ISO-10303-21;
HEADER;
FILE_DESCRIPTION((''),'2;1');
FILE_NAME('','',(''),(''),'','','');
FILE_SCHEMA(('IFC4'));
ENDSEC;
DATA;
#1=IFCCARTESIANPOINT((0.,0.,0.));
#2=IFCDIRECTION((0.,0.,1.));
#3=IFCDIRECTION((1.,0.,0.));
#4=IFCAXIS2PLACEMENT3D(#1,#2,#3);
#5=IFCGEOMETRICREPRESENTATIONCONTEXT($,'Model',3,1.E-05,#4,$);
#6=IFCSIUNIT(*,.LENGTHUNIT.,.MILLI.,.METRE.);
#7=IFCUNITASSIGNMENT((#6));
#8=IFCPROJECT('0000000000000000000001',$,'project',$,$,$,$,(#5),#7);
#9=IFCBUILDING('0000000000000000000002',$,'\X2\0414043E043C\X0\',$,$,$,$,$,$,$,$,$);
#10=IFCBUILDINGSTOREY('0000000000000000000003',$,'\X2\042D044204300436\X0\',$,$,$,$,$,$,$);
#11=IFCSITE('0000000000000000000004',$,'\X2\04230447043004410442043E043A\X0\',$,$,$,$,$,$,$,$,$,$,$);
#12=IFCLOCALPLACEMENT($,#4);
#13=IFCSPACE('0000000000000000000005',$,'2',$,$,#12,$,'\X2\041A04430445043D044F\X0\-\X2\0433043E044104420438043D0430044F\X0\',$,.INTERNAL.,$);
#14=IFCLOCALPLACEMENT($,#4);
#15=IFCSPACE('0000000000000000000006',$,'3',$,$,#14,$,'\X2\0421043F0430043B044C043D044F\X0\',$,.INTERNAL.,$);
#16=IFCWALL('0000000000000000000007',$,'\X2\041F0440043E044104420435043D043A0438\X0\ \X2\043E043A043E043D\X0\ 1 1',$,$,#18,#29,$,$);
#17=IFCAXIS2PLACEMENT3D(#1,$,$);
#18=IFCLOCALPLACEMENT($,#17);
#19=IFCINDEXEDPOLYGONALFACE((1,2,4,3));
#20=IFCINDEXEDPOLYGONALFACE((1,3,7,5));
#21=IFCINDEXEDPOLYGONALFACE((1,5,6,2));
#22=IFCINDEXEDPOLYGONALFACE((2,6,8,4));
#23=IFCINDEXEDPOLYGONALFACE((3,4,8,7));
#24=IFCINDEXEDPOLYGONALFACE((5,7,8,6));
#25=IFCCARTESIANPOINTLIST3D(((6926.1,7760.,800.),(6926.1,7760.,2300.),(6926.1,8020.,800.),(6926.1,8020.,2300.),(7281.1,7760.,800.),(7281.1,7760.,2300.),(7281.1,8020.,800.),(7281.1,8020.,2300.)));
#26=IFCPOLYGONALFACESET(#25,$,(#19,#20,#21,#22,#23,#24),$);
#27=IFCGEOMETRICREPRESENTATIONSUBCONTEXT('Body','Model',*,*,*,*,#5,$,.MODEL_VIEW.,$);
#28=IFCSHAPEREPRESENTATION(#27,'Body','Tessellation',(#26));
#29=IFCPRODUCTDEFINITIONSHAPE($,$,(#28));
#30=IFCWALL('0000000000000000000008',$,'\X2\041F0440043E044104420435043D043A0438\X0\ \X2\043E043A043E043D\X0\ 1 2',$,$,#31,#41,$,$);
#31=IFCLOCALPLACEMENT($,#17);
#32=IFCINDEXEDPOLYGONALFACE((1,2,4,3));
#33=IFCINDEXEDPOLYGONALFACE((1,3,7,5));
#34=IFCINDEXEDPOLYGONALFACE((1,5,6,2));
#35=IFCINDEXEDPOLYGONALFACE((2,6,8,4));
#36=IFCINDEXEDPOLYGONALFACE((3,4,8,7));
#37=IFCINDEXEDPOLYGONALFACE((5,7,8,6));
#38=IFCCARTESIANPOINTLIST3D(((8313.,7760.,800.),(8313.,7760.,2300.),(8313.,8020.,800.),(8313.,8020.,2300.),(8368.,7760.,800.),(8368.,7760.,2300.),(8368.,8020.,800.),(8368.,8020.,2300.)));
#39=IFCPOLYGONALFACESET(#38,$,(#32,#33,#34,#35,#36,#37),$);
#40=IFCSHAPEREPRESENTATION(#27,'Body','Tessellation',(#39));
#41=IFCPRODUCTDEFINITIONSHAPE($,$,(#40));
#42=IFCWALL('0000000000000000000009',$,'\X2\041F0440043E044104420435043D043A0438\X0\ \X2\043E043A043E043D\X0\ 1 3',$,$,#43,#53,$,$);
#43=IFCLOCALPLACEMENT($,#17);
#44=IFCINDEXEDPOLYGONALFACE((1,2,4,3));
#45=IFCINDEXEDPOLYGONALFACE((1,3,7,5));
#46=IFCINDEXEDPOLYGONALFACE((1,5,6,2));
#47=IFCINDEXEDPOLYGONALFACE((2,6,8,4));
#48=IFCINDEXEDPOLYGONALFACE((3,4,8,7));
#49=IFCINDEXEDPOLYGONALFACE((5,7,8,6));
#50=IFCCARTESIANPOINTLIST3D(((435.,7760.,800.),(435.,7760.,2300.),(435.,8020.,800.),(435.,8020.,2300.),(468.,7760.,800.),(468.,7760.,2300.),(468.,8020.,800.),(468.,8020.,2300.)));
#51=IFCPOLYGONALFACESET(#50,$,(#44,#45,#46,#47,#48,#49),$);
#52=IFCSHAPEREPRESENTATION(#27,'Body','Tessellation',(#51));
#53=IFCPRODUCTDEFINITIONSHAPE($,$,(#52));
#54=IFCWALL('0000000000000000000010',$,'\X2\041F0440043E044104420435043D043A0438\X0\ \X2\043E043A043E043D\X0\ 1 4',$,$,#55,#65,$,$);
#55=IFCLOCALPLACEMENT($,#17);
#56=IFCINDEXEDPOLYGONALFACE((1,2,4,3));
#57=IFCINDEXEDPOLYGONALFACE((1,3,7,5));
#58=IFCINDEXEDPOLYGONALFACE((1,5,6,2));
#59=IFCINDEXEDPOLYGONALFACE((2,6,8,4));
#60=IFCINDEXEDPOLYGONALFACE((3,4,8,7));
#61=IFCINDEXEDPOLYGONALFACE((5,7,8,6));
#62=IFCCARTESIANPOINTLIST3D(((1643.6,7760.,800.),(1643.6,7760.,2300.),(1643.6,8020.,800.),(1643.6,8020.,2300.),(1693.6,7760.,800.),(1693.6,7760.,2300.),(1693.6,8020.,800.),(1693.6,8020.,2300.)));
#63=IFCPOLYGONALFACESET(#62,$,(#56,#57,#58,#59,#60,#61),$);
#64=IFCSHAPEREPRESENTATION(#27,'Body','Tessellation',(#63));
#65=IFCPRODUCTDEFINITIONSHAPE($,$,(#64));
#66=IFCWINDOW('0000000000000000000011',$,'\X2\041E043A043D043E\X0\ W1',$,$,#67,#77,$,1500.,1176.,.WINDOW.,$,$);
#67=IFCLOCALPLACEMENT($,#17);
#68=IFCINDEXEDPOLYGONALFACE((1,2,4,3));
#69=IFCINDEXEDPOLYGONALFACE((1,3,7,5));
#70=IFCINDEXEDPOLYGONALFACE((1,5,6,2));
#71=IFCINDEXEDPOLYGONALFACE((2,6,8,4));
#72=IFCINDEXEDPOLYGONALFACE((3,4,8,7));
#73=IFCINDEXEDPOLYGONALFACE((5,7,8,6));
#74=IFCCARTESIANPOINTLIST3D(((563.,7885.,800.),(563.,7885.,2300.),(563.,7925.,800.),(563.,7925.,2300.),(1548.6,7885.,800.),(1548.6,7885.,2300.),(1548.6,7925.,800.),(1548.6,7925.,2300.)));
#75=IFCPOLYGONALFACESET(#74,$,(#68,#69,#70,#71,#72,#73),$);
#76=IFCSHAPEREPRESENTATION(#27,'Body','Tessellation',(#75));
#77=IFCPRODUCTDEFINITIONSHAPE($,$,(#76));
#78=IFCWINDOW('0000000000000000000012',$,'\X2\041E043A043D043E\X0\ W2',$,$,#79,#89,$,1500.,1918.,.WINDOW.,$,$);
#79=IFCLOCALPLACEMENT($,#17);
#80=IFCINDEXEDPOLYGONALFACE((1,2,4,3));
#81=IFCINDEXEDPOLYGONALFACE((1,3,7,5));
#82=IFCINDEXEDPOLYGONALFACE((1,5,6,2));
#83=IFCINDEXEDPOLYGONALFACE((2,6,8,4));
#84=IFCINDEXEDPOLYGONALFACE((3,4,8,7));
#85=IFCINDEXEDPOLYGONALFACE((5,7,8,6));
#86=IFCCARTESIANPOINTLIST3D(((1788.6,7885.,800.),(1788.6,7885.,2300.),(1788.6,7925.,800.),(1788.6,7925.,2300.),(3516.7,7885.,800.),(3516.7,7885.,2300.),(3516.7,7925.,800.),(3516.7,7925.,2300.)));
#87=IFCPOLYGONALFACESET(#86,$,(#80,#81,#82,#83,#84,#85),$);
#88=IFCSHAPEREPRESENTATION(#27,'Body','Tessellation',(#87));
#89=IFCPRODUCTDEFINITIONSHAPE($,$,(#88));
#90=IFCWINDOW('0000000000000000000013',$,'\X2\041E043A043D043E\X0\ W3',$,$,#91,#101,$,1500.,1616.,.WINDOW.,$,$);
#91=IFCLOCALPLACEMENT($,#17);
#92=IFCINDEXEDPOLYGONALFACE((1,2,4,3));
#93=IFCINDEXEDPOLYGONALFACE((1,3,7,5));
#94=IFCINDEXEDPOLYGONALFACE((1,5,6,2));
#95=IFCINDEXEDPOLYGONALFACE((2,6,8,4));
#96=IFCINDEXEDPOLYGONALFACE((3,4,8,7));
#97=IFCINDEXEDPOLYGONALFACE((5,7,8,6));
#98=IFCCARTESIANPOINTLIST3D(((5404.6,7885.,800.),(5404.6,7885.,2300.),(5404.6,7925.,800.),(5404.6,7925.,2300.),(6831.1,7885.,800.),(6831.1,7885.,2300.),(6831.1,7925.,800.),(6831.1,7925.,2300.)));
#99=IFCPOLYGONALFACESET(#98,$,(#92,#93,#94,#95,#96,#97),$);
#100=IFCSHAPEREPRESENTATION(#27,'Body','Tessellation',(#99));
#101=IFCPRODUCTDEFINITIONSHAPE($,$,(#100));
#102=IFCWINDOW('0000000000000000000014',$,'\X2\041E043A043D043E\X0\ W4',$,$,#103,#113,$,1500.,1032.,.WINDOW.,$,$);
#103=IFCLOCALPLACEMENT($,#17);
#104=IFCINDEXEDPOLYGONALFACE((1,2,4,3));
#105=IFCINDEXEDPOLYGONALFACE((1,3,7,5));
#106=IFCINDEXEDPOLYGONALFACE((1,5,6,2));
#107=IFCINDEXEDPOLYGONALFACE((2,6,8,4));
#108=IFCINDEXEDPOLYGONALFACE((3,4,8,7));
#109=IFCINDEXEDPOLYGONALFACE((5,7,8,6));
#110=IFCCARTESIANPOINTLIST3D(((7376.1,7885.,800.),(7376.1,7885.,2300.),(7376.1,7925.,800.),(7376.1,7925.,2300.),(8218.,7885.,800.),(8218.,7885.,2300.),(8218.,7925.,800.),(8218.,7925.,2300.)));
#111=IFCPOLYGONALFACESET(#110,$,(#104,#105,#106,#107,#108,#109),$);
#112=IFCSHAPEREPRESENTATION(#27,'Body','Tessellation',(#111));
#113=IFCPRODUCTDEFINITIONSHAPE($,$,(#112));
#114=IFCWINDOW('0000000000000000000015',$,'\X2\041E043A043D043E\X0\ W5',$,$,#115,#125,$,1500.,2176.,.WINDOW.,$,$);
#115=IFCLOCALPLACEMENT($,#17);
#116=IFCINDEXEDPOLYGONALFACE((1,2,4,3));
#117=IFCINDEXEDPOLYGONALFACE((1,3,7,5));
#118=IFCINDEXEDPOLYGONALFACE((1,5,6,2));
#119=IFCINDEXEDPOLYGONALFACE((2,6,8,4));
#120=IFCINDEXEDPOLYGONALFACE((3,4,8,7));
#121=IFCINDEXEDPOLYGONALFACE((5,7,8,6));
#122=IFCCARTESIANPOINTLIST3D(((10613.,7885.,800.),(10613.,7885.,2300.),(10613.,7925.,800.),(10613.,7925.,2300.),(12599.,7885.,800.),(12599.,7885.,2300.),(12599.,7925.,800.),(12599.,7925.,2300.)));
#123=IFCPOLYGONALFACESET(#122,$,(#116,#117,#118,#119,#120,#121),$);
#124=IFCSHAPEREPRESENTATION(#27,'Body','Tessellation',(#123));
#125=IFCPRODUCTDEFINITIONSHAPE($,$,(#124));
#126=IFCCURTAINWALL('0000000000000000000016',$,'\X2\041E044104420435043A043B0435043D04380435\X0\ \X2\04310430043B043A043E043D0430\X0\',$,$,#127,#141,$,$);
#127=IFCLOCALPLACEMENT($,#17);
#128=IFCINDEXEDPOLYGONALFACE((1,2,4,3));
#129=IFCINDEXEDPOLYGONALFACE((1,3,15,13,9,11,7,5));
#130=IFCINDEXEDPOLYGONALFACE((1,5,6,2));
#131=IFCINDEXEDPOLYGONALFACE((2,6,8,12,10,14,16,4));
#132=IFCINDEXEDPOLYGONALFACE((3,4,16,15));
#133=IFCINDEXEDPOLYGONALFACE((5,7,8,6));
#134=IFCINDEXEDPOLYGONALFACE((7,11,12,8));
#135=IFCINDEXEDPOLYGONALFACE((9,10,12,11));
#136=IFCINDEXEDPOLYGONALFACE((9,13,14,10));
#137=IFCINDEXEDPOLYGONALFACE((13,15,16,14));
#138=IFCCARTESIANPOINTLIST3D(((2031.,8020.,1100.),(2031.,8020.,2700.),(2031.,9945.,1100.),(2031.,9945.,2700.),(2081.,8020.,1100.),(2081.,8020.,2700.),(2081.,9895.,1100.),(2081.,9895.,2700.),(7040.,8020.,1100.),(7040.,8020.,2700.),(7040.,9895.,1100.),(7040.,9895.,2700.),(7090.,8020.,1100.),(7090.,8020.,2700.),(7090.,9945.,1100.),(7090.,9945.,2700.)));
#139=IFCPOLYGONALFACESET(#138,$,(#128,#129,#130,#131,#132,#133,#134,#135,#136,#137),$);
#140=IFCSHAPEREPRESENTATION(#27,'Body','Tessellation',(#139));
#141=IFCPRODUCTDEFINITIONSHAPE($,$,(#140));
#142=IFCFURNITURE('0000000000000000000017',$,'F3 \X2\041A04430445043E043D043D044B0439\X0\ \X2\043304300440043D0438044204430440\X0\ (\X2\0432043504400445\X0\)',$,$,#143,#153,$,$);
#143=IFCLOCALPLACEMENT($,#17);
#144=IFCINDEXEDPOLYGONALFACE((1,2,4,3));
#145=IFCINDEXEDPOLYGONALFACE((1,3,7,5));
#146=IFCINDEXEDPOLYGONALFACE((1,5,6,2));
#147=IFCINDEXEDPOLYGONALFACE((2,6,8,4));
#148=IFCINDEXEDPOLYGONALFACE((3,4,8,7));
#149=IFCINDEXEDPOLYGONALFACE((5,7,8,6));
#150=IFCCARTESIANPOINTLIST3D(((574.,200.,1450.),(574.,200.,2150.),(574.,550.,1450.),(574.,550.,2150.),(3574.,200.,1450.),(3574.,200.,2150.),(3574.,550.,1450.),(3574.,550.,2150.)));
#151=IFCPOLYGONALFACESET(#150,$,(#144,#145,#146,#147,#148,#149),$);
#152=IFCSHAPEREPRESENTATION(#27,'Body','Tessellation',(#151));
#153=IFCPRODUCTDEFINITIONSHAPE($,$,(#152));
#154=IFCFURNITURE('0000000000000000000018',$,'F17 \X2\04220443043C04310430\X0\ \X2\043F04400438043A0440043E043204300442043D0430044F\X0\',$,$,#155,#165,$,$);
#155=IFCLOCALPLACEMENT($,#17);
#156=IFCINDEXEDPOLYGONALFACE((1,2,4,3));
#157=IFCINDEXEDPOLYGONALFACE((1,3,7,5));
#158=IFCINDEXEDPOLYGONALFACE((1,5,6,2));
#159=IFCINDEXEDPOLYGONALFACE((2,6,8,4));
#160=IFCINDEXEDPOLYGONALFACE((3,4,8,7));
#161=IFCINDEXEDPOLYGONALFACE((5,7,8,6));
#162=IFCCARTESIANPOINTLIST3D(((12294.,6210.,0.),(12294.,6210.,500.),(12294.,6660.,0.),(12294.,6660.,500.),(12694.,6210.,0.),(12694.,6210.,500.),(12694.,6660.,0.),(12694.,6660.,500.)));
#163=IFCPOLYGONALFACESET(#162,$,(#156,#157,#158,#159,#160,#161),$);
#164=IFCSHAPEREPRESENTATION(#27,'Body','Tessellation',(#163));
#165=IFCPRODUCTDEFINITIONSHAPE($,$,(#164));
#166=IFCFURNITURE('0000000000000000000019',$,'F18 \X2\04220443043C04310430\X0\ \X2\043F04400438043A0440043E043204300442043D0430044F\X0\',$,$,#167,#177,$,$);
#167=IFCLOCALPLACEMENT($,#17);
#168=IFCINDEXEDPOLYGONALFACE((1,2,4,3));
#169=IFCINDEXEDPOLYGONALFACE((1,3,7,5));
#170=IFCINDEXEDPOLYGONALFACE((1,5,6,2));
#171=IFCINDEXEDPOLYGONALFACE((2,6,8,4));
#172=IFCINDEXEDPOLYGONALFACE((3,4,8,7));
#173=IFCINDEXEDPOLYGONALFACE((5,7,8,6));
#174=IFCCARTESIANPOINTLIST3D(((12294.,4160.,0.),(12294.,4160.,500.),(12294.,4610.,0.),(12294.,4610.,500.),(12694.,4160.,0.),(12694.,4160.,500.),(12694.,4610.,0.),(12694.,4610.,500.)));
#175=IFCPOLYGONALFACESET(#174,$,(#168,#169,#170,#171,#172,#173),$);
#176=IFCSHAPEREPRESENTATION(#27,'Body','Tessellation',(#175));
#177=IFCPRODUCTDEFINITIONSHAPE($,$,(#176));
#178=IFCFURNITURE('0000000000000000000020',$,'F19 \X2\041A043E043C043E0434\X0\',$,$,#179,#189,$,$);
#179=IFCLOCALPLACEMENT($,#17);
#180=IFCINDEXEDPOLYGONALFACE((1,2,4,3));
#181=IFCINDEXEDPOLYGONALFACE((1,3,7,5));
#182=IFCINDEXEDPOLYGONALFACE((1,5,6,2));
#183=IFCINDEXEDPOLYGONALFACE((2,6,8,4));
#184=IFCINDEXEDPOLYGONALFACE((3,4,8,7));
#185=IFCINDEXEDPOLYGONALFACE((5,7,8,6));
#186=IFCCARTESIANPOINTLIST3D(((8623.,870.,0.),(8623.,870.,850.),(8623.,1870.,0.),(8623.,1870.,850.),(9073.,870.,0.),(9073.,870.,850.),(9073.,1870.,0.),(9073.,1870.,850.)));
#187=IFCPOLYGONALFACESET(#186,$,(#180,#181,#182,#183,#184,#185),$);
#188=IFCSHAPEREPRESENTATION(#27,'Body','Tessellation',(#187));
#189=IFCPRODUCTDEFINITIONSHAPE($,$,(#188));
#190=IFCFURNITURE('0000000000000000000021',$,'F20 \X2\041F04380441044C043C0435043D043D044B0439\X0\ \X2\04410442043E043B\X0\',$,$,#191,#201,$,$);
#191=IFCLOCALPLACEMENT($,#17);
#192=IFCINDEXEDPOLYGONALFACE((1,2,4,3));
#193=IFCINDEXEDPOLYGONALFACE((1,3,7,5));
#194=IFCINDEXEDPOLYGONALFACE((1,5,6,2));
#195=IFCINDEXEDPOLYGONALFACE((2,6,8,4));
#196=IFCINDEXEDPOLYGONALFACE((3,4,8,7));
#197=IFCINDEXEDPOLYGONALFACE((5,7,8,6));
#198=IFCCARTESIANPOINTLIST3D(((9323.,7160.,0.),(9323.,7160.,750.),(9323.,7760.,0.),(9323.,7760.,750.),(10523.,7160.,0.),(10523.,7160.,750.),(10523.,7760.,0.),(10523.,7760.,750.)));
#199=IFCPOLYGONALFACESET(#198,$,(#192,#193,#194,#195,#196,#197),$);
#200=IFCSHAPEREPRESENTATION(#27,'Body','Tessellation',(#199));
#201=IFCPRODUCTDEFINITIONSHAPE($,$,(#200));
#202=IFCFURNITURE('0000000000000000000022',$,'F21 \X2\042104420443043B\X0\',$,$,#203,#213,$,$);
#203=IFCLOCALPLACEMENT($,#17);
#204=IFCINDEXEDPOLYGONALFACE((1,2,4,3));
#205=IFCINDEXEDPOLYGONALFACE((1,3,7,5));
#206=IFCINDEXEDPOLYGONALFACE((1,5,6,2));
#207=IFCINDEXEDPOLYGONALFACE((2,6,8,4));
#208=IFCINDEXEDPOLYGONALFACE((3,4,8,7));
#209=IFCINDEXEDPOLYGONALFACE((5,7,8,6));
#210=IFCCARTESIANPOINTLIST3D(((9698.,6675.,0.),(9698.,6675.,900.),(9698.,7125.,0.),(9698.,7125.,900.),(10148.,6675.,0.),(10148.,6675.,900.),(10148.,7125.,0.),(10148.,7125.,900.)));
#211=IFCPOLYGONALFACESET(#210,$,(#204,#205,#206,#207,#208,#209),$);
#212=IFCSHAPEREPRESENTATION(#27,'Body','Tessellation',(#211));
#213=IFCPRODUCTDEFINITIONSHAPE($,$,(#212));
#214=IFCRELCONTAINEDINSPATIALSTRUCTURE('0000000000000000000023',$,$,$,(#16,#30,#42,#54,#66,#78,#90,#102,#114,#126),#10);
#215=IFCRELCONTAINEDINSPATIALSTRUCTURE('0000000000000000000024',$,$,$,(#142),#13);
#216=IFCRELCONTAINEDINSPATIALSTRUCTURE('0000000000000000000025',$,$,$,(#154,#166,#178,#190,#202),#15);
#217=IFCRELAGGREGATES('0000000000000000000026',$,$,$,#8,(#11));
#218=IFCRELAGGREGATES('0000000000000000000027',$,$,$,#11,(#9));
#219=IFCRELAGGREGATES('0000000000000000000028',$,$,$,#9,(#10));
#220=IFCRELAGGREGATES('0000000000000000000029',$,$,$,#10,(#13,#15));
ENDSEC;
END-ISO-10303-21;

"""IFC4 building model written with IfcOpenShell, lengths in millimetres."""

from ifc_helpers import new_model, si_unit, frame, origin, origin_with_axes, place, context, subcontext, project, spatial, polyline, outline, extrude, element, save


model = new_model("IFC4")

# Units and contexts
model_context = context("Model", 3, precision=1e-05, world=origin_with_axes())
body_context = subcontext(model_context, "Body", "Model", "MODEL_VIEW")
ifc_project = project(units=[si_unit("LENGTHUNIT", "METRE", prefix="MILLI")], contexts=[model_context])

# Site, building, storey
site = spatial("IfcSite", under=ifc_project, Name="Участок")
building = spatial("IfcBuilding", under=site, Name="Дом")
storey = spatial("IfcBuildingStorey", under=building, Name="Этаж")

# Walls
wall_1_placement = place(None, frame((0.0, 0.0, 800.0), z_axis=(0.0, 0.0, 1.0), x_axis=(1.0, 0.0, 0.0)))
element("IfcWall", 1, at=wall_1_placement, inside=storey, Name="Простенки окон 1 1", context=body_context, shape_type="SweptSolid", body=[
    extrude(outline(polyline([(7281.1, 8020.0), (7281.1, 7760.0), (6926.1, 7760.0), (6926.1, 8020.0), (7281.1, 8020.0)])), origin(), (0.0, 0.0, 1.0), 1500.0),
])
wall_2_placement = place(None, frame((0.0, 0.0, 800.0), z_axis=(0.0, 0.0, 1.0), x_axis=(1.0, 0.0, 0.0)))
element("IfcWall", 2, at=wall_2_placement, inside=storey, Name="Простенки окон 1 2", context=body_context, shape_type="SweptSolid", body=[
    extrude(outline(polyline([(8368.0, 8020.0), (8368.0, 7760.0), (8313.0, 7760.0), (8313.0, 8020.0), (8368.0, 8020.0)])), origin(), (0.0, 0.0, 1.0), 1500.0),
])
wall_3_placement = place(None, frame((0.0, 0.0, 800.0), z_axis=(0.0, 0.0, 1.0), x_axis=(1.0, 0.0, 0.0)))
element("IfcWall", 3, at=wall_3_placement, inside=storey, Name="Простенки окон 1 3", context=body_context, shape_type="SweptSolid", body=[
    extrude(outline(polyline([(435.0, 8020.0), (468.0, 8020.0), (468.0, 7760.0), (435.0, 7760.0), (435.0, 8020.0)])), origin(), (0.0, 0.0, 1.0), 1500.0),
])
wall_4_placement = place(None, frame((0.0, 0.0, 800.0), z_axis=(0.0, 0.0, 1.0), x_axis=(1.0, 0.0, 0.0)))
element("IfcWall", 4, at=wall_4_placement, inside=storey, Name="Простенки окон 1 4", context=body_context, shape_type="SweptSolid", body=[
    extrude(outline(polyline([(1693.6, 8020.0), (1693.6, 7760.0), (1643.6, 7760.0), (1643.6, 8020.0), (1693.6, 8020.0)])), origin(), (0.0, 0.0, 1.0), 1500.0),
])

# Windows
window_1_placement = place(None, frame((0.0, 0.0, 800.0), z_axis=(0.0, 0.0, 1.0), x_axis=(1.0, 0.0, 0.0)))
element("IfcWindow", 5, at=window_1_placement, inside=storey, Name="Окно W1", OverallHeight=1500.0, OverallWidth=1176.0, PredefinedType="WINDOW", context=body_context, shape_type="SweptSolid", body=[
    extrude(outline(polyline([(563.0, 7925.0), (1548.6, 7925.0), (1548.6, 7885.0), (563.0, 7885.0), (563.0, 7925.0)])), origin(), (0.0, 0.0, 1.0), 1500.0),
])
window_2_placement = place(None, frame((0.0, 0.0, 800.0), z_axis=(0.0, 0.0, 1.0), x_axis=(1.0, 0.0, 0.0)))
element("IfcWindow", 6, at=window_2_placement, inside=storey, Name="Окно W2", OverallHeight=1500.0, OverallWidth=1918.0, PredefinedType="WINDOW", context=body_context, shape_type="SweptSolid", body=[
    extrude(outline(polyline([(1788.6, 7925.0), (3516.7, 7925.0), (3516.7, 7885.0), (1788.6, 7885.0), (1788.6, 7925.0)])), origin(), (0.0, 0.0, 1.0), 1500.0),
])
window_3_placement = place(None, frame((0.0, 0.0, 800.0), z_axis=(0.0, 0.0, 1.0), x_axis=(1.0, 0.0, 0.0)))
element("IfcWindow", 7, at=window_3_placement, inside=storey, Name="Окно W3", OverallHeight=1500.0, OverallWidth=1616.0, PredefinedType="WINDOW", context=body_context, shape_type="SweptSolid", body=[
    extrude(outline(polyline([(5404.6, 7925.0), (6831.1, 7925.0), (6831.1, 7885.0), (5404.6, 7885.0), (5404.6, 7925.0)])), origin(), (0.0, 0.0, 1.0), 1500.0),
])
window_4_placement = place(None, frame((0.0, 0.0, 800.0), z_axis=(0.0, 0.0, 1.0), x_axis=(1.0, 0.0, 0.0)))
element("IfcWindow", 8, at=window_4_placement, inside=storey, Name="Окно W4", OverallHeight=1500.0, OverallWidth=1032.0, PredefinedType="WINDOW", context=body_context, shape_type="SweptSolid", body=[
    extrude(outline(polyline([(7376.1, 7925.0), (8218.0, 7925.0), (8218.0, 7885.0), (7376.1, 7885.0), (7376.1, 7925.0)])), origin(), (0.0, 0.0, 1.0), 1500.0),
])
window_5_placement = place(None, frame((0.0, 0.0, 800.0), z_axis=(0.0, 0.0, 1.0), x_axis=(1.0, 0.0, 0.0)))
element("IfcWindow", 9, at=window_5_placement, inside=storey, Name="Окно W5", OverallHeight=1500.0, OverallWidth=2176.0, PredefinedType="WINDOW", context=body_context, shape_type="SweptSolid", body=[
    extrude(outline(polyline([(12599.0, 7925.0), (12599.0, 7885.0), (10613.0, 7885.0), (10613.0, 7925.0), (12599.0, 7925.0)])), origin(), (0.0, 0.0, 1.0), 1500.0),
])

# Curtain wall
curtain_wall_placement = place(None, frame((0.0, 0.0, 1100.0), z_axis=(0.0, 0.0, 1.0), x_axis=(1.0, 0.0, 0.0)))
element("IfcCurtainWall", 10, at=curtain_wall_placement, inside=storey, Name="Остекление балкона", context=body_context, shape_type="SweptSolid", body=[
    extrude(outline(polyline([(2081.0, 8020.0), (2031.0, 8020.0), (2031.0, 9945.0), (7090.0, 9945.0), (7090.0, 8020.0), (7040.0, 8020.0), (7040.0, 9895.0), (2081.0, 9895.0), (2081.0, 8020.0)])), origin(), (0.0, 0.0, 1.0), 1600.0),
])

# Shared definitions
space_1_placement = place(None, origin_with_axes())
space_1 = spatial("IfcSpace", under=storey, at=space_1_placement, Name="2", LongName="Кухня-гостиная", PredefinedType="INTERNAL")

# Furniture
furniture_1_placement = place(space_1_placement, frame((0.0, 0.0, 1450.0), z_axis=(0.0, 0.0, 1.0), x_axis=(1.0, 0.0, 0.0)))
element("IfcFurniture", 11, at=furniture_1_placement, inside=space_1, Name="F3 Кухонный гарнитур (верх)", context=body_context, shape_type="SweptSolid", body=[
    extrude(outline(polyline([(3574.0, 200.0), (574.0, 200.0), (574.0, 550.0), (3574.0, 550.0), (3574.0, 200.0)])), origin(), (0.0, 0.0, 1.0), 700.0),
])

# Shared definitions
space_2_placement = place(None, origin_with_axes())
space_2 = spatial("IfcSpace", under=storey, at=space_2_placement, Name="3", LongName="Спальня", PredefinedType="INTERNAL")

# Furniture
furniture_2_placement = place(space_2_placement, origin_with_axes())
element("IfcFurniture", 12, at=furniture_2_placement, inside=space_2, Name="F17 Тумба прикроватная", context=body_context, shape_type="SweptSolid", body=[
    extrude(outline(polyline([(12694.0, 6660.0), (12694.0, 6210.0), (12294.0, 6210.0), (12294.0, 6660.0), (12694.0, 6660.0)])), origin(), (0.0, 0.0, 1.0), 500.0),
])
furniture_3_placement = place(space_2_placement, origin_with_axes())
element("IfcFurniture", 13, at=furniture_3_placement, inside=space_2, Name="F18 Тумба прикроватная", context=body_context, shape_type="SweptSolid", body=[
    extrude(outline(polyline([(12694.0, 4610.0), (12694.0, 4160.0), (12294.0, 4160.0), (12294.0, 4610.0), (12694.0, 4610.0)])), origin(), (0.0, 0.0, 1.0), 500.0),
])
furniture_4_placement = place(space_2_placement, origin_with_axes())
element("IfcFurniture", 14, at=furniture_4_placement, inside=space_2, Name="F19 Комод", context=body_context, shape_type="SweptSolid", body=[
    extrude(outline(polyline([(8623.0, 870.0), (8623.0, 1870.0), (9073.0, 1870.0), (9073.0, 870.0), (8623.0, 870.0)])), origin(), (0.0, 0.0, 1.0), 850.0),
])
furniture_5_placement = place(space_2_placement, origin_with_axes())
element("IfcFurniture", 15, at=furniture_5_placement, inside=space_2, Name="F20 Письменный стол", context=body_context, shape_type="SweptSolid", body=[
    extrude(outline(polyline([(9323.0, 7760.0), (10523.0, 7760.0), (10523.0, 7160.0), (9323.0, 7160.0), (9323.0, 7760.0)])), origin(), (0.0, 0.0, 1.0), 750.0),
])
furniture_6_placement = place(space_2_placement, origin_with_axes())
element("IfcFurniture", 16, at=furniture_6_placement, inside=space_2, Name="F21 Стул", context=body_context, shape_type="SweptSolid", body=[
    extrude(outline(polyline([(10148.0, 6675.0), (10148.0, 7125.0), (9698.0, 7125.0), (9698.0, 6675.0), (10148.0, 6675.0)])), origin(), (0.0, 0.0, 1.0), 900.0),
])

save(model, "model.ifc")
